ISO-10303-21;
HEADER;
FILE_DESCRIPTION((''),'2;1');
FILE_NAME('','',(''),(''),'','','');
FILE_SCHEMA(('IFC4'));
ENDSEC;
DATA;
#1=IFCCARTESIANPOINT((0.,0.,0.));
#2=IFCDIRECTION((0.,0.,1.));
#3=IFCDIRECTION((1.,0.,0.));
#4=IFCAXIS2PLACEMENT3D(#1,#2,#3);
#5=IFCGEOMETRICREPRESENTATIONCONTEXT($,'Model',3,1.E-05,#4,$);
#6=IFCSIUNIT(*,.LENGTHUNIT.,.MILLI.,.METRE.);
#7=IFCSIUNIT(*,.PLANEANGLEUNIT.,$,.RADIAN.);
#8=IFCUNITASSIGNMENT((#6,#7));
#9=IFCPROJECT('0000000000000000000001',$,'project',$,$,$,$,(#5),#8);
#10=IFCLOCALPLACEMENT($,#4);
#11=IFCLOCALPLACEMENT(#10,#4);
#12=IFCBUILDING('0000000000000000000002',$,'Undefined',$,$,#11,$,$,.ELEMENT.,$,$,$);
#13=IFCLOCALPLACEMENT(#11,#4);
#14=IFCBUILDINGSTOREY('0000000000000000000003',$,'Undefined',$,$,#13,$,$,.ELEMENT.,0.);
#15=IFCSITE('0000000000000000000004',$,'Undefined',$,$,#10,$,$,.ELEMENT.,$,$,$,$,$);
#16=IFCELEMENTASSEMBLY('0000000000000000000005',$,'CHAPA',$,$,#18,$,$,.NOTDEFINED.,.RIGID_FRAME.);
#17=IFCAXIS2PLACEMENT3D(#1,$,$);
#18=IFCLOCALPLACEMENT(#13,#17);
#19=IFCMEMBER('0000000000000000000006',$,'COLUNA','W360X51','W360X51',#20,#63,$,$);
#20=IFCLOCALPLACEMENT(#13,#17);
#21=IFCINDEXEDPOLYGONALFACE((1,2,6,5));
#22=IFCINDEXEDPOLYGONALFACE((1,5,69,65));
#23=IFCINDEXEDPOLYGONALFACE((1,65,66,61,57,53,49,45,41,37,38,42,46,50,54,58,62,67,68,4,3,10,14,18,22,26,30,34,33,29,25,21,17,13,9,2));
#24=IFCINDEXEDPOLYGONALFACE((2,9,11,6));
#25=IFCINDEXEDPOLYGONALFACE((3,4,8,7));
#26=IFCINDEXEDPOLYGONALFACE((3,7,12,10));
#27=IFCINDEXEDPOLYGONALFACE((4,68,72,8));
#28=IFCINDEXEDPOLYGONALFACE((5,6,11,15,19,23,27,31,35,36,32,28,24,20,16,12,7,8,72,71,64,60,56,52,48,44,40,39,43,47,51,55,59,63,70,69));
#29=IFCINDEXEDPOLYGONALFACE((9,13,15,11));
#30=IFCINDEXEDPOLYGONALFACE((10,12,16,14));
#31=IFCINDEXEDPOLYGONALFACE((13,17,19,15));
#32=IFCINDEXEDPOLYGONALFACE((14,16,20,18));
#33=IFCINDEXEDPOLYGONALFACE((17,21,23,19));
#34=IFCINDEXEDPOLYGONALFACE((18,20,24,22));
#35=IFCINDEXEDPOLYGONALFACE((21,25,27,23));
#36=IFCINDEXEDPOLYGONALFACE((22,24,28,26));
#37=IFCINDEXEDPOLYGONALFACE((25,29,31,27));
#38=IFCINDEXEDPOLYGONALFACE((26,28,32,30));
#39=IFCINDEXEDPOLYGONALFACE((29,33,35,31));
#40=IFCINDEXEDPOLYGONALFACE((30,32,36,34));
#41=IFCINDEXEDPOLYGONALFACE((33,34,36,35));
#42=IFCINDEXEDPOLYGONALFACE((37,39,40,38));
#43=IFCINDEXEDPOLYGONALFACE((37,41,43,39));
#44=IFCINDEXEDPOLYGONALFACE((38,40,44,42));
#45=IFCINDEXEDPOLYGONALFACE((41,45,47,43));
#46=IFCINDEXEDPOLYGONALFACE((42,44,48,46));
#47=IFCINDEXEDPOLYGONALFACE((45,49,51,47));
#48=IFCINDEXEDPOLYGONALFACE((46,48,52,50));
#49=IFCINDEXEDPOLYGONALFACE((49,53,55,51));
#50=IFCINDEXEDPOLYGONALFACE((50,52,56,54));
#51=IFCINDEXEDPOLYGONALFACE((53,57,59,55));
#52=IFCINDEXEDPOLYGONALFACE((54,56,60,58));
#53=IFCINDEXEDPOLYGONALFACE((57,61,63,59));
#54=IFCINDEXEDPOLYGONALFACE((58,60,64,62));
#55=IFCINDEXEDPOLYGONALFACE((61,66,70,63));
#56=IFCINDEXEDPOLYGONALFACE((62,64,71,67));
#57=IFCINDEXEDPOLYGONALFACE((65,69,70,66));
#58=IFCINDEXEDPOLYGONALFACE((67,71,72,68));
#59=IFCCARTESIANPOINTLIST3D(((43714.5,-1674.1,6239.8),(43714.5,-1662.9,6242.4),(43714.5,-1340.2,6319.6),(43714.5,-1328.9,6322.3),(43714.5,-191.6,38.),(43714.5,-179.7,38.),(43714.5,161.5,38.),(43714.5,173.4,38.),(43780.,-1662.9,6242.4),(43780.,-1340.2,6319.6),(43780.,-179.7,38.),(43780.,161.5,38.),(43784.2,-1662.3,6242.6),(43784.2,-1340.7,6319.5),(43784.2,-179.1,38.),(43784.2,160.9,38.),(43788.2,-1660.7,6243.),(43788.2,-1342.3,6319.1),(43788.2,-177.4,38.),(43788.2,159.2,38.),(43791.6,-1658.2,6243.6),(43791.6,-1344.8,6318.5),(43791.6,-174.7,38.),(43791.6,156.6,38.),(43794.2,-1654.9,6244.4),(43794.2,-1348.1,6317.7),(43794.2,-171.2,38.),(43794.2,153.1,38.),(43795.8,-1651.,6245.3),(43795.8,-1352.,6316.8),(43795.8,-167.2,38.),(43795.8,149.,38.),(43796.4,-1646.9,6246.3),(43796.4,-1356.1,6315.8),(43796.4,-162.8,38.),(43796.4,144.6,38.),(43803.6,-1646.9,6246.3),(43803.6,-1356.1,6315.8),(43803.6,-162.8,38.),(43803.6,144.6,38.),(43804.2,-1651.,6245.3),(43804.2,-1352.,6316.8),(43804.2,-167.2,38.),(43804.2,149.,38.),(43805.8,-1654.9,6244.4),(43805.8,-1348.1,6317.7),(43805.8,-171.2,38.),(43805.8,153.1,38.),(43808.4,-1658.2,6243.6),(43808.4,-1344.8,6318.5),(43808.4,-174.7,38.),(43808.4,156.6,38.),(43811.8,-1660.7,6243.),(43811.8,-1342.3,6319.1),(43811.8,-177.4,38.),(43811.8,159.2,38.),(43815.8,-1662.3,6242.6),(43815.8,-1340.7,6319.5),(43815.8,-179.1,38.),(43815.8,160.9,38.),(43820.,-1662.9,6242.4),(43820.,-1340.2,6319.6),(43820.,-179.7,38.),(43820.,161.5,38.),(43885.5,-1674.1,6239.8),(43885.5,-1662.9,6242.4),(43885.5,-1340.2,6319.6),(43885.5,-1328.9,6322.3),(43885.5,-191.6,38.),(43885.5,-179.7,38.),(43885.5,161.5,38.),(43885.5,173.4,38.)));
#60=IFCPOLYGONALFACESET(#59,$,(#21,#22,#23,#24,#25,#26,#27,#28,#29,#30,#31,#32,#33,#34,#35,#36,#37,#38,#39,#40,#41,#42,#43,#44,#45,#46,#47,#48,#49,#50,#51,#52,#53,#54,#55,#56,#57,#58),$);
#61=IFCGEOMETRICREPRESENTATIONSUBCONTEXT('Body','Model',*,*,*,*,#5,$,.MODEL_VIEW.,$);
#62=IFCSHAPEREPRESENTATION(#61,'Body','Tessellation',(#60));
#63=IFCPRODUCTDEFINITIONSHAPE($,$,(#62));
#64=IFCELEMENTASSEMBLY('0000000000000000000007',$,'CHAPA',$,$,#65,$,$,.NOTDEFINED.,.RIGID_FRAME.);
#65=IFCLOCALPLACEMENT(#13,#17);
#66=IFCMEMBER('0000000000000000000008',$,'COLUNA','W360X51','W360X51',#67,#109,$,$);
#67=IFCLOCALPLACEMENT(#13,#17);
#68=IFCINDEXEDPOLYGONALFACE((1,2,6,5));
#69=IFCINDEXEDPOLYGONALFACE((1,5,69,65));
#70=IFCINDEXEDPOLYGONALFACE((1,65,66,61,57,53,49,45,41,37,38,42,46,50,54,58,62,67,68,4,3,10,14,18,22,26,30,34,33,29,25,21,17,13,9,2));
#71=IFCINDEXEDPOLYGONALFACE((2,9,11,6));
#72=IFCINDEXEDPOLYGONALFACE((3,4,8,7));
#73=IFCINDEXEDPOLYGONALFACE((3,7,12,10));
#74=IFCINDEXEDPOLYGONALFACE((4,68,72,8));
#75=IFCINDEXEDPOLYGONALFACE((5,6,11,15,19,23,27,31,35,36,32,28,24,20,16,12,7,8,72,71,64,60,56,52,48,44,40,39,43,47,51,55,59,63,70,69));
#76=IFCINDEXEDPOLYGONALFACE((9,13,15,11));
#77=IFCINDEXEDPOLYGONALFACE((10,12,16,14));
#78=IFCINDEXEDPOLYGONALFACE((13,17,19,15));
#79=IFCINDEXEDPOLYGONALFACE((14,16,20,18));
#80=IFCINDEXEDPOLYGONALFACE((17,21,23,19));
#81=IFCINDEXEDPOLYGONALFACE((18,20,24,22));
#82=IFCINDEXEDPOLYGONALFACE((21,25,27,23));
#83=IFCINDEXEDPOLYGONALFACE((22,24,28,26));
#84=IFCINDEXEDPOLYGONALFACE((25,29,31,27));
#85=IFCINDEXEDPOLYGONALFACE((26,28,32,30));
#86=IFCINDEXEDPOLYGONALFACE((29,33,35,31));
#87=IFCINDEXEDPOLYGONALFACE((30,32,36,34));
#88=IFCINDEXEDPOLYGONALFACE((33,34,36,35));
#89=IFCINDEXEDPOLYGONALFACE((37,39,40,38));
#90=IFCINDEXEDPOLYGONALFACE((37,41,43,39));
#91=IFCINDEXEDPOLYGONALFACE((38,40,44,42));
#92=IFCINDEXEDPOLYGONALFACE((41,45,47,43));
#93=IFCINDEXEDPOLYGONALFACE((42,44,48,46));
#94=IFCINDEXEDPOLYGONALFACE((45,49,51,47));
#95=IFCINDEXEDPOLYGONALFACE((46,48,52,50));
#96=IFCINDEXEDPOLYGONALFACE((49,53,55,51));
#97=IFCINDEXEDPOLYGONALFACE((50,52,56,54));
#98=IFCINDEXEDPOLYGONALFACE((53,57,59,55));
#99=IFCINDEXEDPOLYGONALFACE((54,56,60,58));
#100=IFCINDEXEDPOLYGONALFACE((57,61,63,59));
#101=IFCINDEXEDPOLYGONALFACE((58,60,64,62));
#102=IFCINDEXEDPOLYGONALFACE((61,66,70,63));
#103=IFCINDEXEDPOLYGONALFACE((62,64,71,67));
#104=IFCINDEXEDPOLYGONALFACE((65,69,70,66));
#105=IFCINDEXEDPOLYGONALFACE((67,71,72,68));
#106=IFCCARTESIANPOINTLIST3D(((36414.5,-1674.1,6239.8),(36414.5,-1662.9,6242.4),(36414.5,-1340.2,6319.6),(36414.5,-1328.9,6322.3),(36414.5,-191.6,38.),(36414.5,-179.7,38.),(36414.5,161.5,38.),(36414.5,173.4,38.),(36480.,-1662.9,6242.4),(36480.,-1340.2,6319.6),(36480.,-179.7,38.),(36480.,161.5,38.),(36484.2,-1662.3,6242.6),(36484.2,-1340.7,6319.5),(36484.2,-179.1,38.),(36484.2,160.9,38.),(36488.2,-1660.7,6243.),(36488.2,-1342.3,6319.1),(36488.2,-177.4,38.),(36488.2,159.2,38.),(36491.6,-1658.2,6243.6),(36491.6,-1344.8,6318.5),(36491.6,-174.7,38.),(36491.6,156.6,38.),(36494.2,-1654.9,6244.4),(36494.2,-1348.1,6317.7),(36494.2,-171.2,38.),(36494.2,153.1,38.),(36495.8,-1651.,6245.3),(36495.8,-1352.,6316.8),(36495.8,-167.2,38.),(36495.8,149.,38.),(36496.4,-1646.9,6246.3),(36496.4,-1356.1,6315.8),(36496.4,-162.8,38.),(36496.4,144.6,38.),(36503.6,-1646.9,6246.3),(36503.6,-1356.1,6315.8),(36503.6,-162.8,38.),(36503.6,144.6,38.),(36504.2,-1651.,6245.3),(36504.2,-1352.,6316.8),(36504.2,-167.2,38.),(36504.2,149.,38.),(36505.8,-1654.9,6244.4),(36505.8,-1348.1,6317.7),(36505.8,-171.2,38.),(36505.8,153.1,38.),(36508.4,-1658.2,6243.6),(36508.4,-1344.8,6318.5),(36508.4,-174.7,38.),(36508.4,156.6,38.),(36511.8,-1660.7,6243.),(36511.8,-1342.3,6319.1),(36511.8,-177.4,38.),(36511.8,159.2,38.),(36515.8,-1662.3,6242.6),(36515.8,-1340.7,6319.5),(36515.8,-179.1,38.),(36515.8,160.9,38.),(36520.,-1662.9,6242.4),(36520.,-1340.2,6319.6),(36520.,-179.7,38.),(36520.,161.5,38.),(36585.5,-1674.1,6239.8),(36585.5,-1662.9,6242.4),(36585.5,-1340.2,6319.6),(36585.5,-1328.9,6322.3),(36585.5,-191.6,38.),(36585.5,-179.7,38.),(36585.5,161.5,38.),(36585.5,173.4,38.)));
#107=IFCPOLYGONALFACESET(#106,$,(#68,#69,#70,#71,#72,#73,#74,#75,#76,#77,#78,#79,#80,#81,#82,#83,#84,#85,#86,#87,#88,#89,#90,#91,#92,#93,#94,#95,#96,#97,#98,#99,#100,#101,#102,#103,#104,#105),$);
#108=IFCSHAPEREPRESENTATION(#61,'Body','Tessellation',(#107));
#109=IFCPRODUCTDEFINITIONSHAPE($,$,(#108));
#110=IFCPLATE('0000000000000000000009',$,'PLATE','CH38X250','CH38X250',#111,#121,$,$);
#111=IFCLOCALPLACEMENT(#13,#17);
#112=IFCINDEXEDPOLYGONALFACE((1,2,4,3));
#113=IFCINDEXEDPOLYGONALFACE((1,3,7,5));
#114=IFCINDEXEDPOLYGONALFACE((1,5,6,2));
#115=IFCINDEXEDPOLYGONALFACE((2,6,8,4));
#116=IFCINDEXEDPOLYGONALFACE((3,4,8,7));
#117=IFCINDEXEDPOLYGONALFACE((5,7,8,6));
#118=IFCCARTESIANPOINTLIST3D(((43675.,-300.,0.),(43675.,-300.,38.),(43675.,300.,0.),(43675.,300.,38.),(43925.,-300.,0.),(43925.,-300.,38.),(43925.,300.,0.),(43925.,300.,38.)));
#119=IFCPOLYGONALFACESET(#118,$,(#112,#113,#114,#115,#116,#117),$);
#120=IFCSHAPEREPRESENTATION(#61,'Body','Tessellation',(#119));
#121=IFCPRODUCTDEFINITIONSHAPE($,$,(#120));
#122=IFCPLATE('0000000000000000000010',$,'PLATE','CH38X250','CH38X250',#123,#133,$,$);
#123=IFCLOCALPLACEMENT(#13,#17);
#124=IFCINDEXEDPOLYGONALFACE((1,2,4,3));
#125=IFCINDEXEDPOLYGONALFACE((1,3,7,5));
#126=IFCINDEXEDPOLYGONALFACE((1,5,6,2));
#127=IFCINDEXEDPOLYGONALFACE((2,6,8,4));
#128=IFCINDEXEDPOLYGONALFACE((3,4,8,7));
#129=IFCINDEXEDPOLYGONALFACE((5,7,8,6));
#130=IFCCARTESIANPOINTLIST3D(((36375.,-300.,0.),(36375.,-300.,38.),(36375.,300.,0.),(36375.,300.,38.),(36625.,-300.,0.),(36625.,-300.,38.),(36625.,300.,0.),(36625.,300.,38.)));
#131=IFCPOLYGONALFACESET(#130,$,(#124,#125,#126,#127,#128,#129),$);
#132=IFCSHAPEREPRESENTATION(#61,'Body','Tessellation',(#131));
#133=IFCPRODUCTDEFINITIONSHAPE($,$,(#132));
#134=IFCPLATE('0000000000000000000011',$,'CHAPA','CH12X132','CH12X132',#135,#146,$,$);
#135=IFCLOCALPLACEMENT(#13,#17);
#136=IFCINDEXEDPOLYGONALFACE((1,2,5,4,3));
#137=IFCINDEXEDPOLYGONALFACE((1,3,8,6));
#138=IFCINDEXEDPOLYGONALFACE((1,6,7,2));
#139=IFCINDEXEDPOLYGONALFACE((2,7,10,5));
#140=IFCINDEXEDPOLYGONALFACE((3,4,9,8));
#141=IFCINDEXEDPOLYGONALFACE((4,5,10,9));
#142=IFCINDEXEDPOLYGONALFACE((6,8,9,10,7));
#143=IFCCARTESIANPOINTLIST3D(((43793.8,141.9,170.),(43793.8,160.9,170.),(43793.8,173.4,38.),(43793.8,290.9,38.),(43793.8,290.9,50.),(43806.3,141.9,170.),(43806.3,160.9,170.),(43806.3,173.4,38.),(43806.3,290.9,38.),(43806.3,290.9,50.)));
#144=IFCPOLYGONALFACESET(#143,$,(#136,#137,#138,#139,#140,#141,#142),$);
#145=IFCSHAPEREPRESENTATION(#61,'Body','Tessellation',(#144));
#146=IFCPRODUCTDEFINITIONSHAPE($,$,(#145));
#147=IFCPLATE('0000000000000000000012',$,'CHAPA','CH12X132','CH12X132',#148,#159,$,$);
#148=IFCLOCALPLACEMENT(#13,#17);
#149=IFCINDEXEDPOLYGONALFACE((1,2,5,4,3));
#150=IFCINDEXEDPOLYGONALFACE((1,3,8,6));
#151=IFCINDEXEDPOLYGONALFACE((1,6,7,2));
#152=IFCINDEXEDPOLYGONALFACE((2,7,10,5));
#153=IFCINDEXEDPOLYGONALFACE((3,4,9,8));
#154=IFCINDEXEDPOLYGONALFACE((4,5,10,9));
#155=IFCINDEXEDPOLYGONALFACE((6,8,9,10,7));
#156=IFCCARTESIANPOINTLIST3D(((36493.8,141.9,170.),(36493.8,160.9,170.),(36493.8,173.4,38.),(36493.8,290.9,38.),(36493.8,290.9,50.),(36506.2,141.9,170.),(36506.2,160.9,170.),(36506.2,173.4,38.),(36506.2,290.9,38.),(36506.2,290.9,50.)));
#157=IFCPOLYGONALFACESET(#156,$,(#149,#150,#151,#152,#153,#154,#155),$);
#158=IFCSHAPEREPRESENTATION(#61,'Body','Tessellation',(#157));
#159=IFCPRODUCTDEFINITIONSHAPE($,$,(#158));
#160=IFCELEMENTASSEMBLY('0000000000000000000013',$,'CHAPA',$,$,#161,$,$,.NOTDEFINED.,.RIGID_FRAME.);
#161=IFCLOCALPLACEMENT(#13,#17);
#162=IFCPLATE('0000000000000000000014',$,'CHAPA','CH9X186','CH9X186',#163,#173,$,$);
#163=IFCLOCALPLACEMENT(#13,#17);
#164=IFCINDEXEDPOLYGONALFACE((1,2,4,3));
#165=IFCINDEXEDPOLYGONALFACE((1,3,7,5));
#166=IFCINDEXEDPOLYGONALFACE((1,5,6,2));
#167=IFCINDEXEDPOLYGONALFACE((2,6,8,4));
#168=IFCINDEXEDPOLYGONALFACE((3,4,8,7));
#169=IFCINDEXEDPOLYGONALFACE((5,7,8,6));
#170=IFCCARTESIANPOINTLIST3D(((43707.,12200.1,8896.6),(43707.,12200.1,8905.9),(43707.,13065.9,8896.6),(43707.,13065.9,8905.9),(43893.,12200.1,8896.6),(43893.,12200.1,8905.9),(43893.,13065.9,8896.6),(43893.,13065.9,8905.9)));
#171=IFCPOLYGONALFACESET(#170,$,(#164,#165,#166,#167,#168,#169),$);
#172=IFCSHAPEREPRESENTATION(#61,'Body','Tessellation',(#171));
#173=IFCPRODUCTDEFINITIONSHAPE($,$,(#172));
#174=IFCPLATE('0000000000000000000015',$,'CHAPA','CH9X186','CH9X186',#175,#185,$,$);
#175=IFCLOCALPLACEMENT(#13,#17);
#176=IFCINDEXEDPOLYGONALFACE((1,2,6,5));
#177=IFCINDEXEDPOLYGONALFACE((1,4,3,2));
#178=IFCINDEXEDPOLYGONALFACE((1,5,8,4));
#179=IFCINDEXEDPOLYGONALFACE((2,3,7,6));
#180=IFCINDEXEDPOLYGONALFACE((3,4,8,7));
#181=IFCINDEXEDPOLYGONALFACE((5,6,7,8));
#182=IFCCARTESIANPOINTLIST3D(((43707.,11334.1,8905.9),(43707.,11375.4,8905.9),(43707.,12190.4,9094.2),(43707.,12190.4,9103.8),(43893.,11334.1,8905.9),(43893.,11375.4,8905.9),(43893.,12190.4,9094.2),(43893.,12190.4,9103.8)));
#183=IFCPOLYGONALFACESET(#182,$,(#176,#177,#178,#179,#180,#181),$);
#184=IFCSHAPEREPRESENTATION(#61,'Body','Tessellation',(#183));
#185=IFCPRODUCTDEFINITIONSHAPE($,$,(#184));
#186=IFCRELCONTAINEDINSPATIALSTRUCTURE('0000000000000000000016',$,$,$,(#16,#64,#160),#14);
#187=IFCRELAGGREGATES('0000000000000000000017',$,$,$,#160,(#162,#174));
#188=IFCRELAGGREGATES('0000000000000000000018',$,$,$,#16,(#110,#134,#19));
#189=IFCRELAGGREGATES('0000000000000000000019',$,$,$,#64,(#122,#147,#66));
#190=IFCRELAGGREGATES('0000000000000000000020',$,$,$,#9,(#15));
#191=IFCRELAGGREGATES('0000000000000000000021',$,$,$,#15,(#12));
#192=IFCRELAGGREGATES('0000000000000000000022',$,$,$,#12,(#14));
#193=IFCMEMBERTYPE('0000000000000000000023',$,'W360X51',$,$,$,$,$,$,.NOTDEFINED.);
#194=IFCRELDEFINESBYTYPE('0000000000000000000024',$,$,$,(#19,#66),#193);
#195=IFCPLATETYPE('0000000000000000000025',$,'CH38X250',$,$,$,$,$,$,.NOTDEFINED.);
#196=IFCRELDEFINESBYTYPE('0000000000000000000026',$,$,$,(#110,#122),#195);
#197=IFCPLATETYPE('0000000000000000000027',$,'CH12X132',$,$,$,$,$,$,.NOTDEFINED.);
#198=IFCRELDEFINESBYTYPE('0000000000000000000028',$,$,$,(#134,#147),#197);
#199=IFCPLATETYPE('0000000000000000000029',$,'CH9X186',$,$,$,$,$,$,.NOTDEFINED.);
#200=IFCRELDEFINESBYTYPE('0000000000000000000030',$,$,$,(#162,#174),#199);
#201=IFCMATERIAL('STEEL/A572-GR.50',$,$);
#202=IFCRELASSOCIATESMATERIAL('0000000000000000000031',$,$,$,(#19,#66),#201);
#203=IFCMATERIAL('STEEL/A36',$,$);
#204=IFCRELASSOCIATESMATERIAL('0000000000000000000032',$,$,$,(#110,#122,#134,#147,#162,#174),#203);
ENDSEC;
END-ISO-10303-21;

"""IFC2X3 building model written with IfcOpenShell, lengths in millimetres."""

from ifc_helpers import new_model, si_unit, frame, origin_with_axes, origin_2d_with_axis, place, context, subcontext, project, spatial, polyline, i_section, outline, extrude, clip, halfspace, material, type_object, element, aggregate, save


model = new_model("IFC2X3")

# Units and contexts
model_context = context("Model", 3, precision=1e-05, world=origin_with_axes())
body_context = subcontext(model_context, "Body", "Model", "MODEL_VIEW")
ifc_project = project(units=[si_unit("LENGTHUNIT", "METRE", prefix="MILLI"), si_unit("PLANEANGLEUNIT", "RADIAN")], contexts=[model_context])

# Site, building, storey
site_placement = place(None, origin_with_axes())
site = spatial("IfcSite", under=ifc_project, at=site_placement, Name="Undefined", CompositionType="ELEMENT")
building_placement = place(site_placement, origin_with_axes())
building = spatial("IfcBuilding", under=site, at=building_placement, Name="Undefined", CompositionType="ELEMENT")
storey_placement = place(building_placement, origin_with_axes())
storey = spatial("IfcBuildingStorey", under=building, at=storey_placement, Name="Undefined", CompositionType="ELEMENT", Elevation=0.0)

# Element assemblies, members
assembly_1_placement = place(storey_placement, origin_with_axes())
assembly_1 = element("IfcElementAssembly", 1, at=assembly_1_placement, inside=storey, Name="CHAPA", AssemblyPlace="NOTDEFINED", PredefinedType="RIGID_FRAME")
ifc_material_1 = material(Name="STEEL/A572-GR.50")
member_type = type_object("IfcMemberType", Name="W360X51", PredefinedType="NOTDEFINED")
member_1_placement = place(assembly_1_placement, frame((43800.0, 23.3, -97.3), z_axis=(0.0, -0.972595, -0.232504), x_axis=(0.0, -0.232504, 0.972595)))
member_1 = element("IfcMember", 2, at=member_1_placement, type_object=member_type, material=ifc_material_1, Name="COLUNA", Description="W360X51", ObjectType="W360X51", context=body_context, shape_type="Clipping", body=[
    clip(clip(extrude(i_section(OverallWidth=171.0, OverallDepth=355.0, WebThickness=7.2, FlangeThickness=11.6, FilletRadius=16.4, at=origin_2d_with_axis()), frame((6558.0, 0.0, 0.0), z_axis=(-1.0, 0.0, 0.0), x_axis=(0.0, -1.0, 0.0)), (0.0, 0.0, 1.0), 6542.9), halfspace(frame((94.5, 85.5, -186.3), z_axis=(-0.972595, 0.0, 0.232504), x_axis=(0.232504, 0.0, 0.972595)), False)), halfspace(frame((96.6, 0.0, -177.5), z_axis=(0.972595, 0.0, -0.232504), x_axis=(0.0, -1.0, 0.0)), True)),
])
assembly_2_placement = place(storey_placement, origin_with_axes())
assembly_2 = element("IfcElementAssembly", 3, at=assembly_2_placement, inside=storey, Name="CHAPA", AssemblyPlace="NOTDEFINED", PredefinedType="RIGID_FRAME")
member_2_placement = place(assembly_2_placement, frame((36500.0, 23.3, -97.3), z_axis=(0.0, -0.972595, -0.232504), x_axis=(0.0, -0.232504, 0.972595)))
member_2 = element("IfcMember", 4, at=member_2_placement, type_object=member_type, material=ifc_material_1, Name="COLUNA", Description="W360X51", ObjectType="W360X51", context=body_context, shape_type="Clipping", body=[
    clip(clip(extrude(i_section(OverallWidth=171.0, OverallDepth=355.0, WebThickness=7.2, FlangeThickness=11.6, FilletRadius=16.4, at=origin_2d_with_axis()), frame((6558.0, 0.0, 0.0), z_axis=(-1.0, 0.0, 0.0), x_axis=(0.0, -1.0, 0.0)), (0.0, 0.0, 1.0), 6542.9), halfspace(frame((94.5, 85.5, -186.3), z_axis=(-0.972595, 0.0, 0.232504), x_axis=(0.232504, 0.0, 0.972595)), False)), halfspace(frame((96.6, 0.0, -177.5), z_axis=(0.972595, 0.0, -0.232504), x_axis=(0.0, -1.0, 0.0)), True)),
])

# Plates
ifc_material_2 = material(Name="STEEL/A36")
plate_type_1 = type_object("IfcPlateType", Name="CH38X250", PredefinedType="NOTDEFINED")
plate_1_placement = place(assembly_1_placement, frame((43925.0, -300.0, 19.0), z_axis=(0.0, 0.0, 1.0), x_axis=(0.0, 1.0, 0.0)))
plate_1 = element("IfcPlate", 5, at=plate_1_placement, type_object=plate_type_1, material=ifc_material_2, Name="PLATE", Description="CH38X250", ObjectType="CH38X250", context=body_context, shape_type="SweptSolid", body=[
    extrude(outline(polyline([(0.0, 0.0), (600.0, 0.0), (600.0, 250.0), (0.0, 250.0), (0.0, 0.0)])), frame((0.0, 0.0, -19.0), z_axis=(0.0, 0.0, 1.0), x_axis=(1.0, 0.0, 0.0)), (0.0, 0.0, 1.0), 38.0),
])
plate_2_placement = place(assembly_2_placement, frame((36625.0, -300.0, 19.0), z_axis=(0.0, 0.0, 1.0), x_axis=(0.0, 1.0, 0.0)))
plate_2 = element("IfcPlate", 6, at=plate_2_placement, type_object=plate_type_1, material=ifc_material_2, Name="PLATE", Description="CH38X250", ObjectType="CH38X250", context=body_context, shape_type="SweptSolid", body=[
    extrude(outline(polyline([(0.0, 0.0), (600.0, 0.0), (600.0, 250.0), (0.0, 250.0), (0.0, 0.0)])), frame((0.0, 0.0, -19.0), z_axis=(0.0, 0.0, 1.0), x_axis=(1.0, 0.0, 0.0)), (0.0, 0.0, 1.0), 38.0),
])
plate_type_2 = type_object("IfcPlateType", Name="CH12X132", PredefinedType="NOTDEFINED")
plate_3_placement = place(assembly_1_placement, frame((43800.0, 173.4, 38.0), z_axis=(1.0, 0.0, 0.0), x_axis=(0.0, 1.0, 0.0)))
plate_3 = element("IfcPlate", 7, at=plate_3_placement, type_object=plate_type_2, material=ifc_material_2, Name="CHAPA", Description="CH12X132", ObjectType="CH12X132", context=body_context, shape_type="SweptSolid", body=[
    extrude(outline(polyline([(0.0, 0.0), (117.5, 0.0), (117.5, 12.0), (-12.5, 132.0), (-31.6, 132.0), (0.0, 0.0)])), frame((0.0, 0.0, -6.2), z_axis=(0.0, 0.0, 1.0), x_axis=(1.0, 0.0, 0.0)), (0.0, 0.0, 1.0), 12.5),
])
plate_4_placement = place(assembly_2_placement, frame((36500.0, 173.4, 38.0), z_axis=(1.0, 0.0, 0.0), x_axis=(0.0, 1.0, 0.0)))
plate_4 = element("IfcPlate", 8, at=plate_4_placement, type_object=plate_type_2, material=ifc_material_2, Name="CHAPA", Description="CH12X132", ObjectType="CH12X132", context=body_context, shape_type="SweptSolid", body=[
    extrude(outline(polyline([(0.0, 0.0), (117.5, 0.0), (117.5, 12.0), (-12.5, 132.0), (-31.6, 132.0), (0.0, 0.0)])), frame((0.0, 0.0, -6.2), z_axis=(0.0, 0.0, 1.0), x_axis=(1.0, 0.0, 0.0)), (0.0, 0.0, 1.0), 12.5),
])

# Element assembly, plates
assembly_3_placement = place(storey_placement, origin_with_axes())
assembly_3 = element("IfcElementAssembly", 9, at=assembly_3_placement, inside=storey, Name="CHAPA", AssemblyPlace="NOTDEFINED", PredefinedType="RIGID_FRAME")
plate_type_3 = type_object("IfcPlateType", Name="CH9X186", PredefinedType="NOTDEFINED")
plate_5_placement = place(assembly_3_placement, frame((43893.0, 12200.1, 8901.3), z_axis=(0.0, 0.0, -1.0), x_axis=(-1.0, 0.0, 0.0)))
plate_5 = element("IfcPlate", 10, at=plate_5_placement, type_object=plate_type_3, material=ifc_material_2, Name="CHAPA", Description="CH9X186", ObjectType="CH9X186", context=body_context, shape_type="SweptSolid", body=[
    extrude(outline(polyline([(0.0, 0.0), (186.0, 0.0), (186.0, 865.8), (0.0, 865.8), (0.0, 0.0)])), frame((0.0, 0.0, -4.7), z_axis=(0.0, 0.0, 1.0), x_axis=(1.0, 0.0, 0.0)), (0.0, 0.0, 1.0), 9.3),
])
plate_6_placement = place(assembly_3_placement, frame((43893.0, 12191.4, 9099.3), z_axis=(0.0, -0.225125, 0.97433), x_axis=(-1.0, 0.0, 0.0)))
plate_6 = element("IfcPlate", 11, at=plate_6_placement, type_object=plate_type_3, material=ifc_material_2, Name="CHAPA", Description="CH9X186", ObjectType="CH9X186", context=body_context, shape_type="Clipping", body=[
    clip(clip(extrude(outline(polyline([(0.0, 0.0), (186.0, 0.0), (186.0, 878.9), (0.0, 878.9), (0.0, 0.0)])), frame((0.0, 0.0, -4.7), z_axis=(0.0, 0.0, 1.0), x_axis=(1.0, 0.0, 0.0)), (0.0, 0.0, 1.0), 9.3), halfspace(frame((186.0, -500.0, -314.0), z_axis=(0.0, 0.225128, -0.974329), x_axis=(0.0, 0.974329, 0.225128)), False)), halfspace(frame((0.0, 2.1, -4.6), z_axis=(0.0, -0.97433, -0.225125), x_axis=(0.0, -0.225125, 0.97433)), False)),
])

aggregate(assembly_3, [plate_5, plate_6])

aggregate(assembly_1, [plate_1, plate_3, member_1])
aggregate(assembly_2, [plate_2, plate_4, member_2])

save(model, "model.ifc")
